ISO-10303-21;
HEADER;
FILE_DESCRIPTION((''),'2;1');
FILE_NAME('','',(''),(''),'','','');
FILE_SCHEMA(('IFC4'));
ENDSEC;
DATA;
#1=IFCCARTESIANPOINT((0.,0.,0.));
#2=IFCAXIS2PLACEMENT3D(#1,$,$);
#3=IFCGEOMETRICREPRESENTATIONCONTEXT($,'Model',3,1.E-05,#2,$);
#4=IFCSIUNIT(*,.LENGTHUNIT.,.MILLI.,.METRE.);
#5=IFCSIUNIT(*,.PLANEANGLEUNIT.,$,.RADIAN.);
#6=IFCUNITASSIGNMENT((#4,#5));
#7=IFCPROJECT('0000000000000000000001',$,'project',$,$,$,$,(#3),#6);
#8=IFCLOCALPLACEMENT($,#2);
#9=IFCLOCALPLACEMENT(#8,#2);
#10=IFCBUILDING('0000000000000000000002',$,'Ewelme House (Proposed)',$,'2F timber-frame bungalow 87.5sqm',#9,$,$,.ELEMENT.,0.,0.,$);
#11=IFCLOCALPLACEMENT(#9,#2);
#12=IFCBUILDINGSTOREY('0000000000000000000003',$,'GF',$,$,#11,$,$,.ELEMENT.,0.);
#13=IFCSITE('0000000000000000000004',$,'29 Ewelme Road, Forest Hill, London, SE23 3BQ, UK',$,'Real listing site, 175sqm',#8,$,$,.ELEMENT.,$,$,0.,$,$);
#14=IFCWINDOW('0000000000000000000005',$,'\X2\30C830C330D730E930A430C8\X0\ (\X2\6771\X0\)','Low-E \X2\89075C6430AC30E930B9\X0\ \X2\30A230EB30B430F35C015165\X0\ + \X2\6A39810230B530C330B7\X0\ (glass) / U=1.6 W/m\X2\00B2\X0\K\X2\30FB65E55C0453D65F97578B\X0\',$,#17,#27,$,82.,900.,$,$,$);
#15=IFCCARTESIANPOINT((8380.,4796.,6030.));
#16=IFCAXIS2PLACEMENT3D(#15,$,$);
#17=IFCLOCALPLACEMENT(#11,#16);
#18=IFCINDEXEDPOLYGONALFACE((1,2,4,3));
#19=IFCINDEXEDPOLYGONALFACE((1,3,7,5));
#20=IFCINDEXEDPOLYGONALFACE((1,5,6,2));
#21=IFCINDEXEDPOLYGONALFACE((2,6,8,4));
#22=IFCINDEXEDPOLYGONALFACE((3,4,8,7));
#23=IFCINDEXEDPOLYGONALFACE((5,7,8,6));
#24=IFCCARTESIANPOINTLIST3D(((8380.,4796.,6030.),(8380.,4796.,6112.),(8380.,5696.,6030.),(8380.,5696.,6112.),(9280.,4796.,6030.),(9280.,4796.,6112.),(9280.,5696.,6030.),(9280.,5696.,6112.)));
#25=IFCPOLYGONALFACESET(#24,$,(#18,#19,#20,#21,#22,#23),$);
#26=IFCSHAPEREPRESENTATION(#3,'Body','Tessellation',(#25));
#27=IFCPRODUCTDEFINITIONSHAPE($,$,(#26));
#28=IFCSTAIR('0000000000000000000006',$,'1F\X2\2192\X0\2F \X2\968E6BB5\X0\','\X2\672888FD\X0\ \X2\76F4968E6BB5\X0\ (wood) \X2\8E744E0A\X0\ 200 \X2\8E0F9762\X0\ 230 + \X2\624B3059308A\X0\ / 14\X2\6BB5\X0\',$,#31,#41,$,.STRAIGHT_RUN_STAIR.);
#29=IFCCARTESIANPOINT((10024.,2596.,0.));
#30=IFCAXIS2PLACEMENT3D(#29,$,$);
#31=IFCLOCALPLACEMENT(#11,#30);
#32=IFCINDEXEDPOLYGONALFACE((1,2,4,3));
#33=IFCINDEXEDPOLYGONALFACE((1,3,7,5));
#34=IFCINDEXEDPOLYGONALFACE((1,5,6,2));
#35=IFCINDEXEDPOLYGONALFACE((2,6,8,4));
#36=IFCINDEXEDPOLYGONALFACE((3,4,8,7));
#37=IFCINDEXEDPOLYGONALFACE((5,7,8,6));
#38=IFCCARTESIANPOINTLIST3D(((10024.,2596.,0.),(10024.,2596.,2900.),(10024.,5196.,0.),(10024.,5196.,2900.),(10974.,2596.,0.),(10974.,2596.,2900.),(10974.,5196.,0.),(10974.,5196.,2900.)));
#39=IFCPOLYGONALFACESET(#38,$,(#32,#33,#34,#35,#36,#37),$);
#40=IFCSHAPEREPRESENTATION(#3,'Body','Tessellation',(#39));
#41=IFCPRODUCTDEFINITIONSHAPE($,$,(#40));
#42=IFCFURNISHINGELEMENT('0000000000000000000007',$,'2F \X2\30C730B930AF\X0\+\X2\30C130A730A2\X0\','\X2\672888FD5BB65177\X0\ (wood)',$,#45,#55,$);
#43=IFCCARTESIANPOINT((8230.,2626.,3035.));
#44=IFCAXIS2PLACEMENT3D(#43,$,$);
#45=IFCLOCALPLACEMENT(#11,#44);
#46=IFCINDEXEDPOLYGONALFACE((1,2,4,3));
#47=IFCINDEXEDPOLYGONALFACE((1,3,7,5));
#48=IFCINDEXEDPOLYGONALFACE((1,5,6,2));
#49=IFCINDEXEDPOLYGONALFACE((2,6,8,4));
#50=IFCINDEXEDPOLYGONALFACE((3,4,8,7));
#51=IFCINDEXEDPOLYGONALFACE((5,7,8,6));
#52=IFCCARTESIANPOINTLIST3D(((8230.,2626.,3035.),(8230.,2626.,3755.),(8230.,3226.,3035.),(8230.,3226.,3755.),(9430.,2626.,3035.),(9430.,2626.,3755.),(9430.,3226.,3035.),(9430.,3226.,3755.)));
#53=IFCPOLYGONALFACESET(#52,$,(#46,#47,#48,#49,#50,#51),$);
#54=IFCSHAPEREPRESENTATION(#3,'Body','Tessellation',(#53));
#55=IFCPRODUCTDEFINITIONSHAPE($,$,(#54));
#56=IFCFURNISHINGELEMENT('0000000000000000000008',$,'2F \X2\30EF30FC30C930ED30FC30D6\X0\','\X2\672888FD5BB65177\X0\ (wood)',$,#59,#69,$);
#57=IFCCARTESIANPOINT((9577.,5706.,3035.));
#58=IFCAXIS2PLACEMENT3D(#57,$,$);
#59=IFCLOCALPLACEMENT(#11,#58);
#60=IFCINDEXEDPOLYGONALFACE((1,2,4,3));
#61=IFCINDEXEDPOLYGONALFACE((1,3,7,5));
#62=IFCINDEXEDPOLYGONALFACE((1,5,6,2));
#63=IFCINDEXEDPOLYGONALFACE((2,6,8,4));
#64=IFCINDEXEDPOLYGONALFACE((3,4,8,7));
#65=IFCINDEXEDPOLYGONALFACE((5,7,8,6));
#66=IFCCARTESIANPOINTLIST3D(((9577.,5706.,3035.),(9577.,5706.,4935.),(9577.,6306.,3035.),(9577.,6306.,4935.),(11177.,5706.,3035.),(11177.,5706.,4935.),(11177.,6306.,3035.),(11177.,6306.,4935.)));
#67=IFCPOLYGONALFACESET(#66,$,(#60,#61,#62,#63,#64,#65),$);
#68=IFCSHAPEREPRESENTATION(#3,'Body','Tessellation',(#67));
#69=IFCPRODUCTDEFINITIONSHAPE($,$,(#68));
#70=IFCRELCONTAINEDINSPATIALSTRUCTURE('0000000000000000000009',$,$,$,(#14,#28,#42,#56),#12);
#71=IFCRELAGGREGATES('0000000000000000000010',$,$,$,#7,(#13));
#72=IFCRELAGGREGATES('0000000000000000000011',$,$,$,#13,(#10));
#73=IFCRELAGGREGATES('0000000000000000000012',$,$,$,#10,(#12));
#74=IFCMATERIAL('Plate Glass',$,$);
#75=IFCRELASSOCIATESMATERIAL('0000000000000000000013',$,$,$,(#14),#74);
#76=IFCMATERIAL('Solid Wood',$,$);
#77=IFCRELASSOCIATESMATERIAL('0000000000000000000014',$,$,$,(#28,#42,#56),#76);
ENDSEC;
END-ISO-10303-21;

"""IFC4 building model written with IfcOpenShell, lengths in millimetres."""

from ifc_helpers import new_model, si_unit, frame, frame_2d, origin, place, context, project, spatial, rectangle, extrude, material, element, save


model = new_model("IFC4")

# Units and contexts
model_context = context("Model", 3, precision=1e-05, world=origin())
ifc_project = project(units=[si_unit("LENGTHUNIT", "METRE", prefix="MILLI"), si_unit("PLANEANGLEUNIT", "RADIAN")], contexts=[model_context])

# Site, building, storey
site_placement = place(None, origin())
site = spatial("IfcSite", under=ifc_project, at=site_placement, Name="29 Ewelme Road, Forest Hill, London, SE23 3BQ, UK", ObjectType="Real listing site, 175sqm", CompositionType="ELEMENT", RefElevation=0.0)
building_placement = place(site_placement, origin())
building = spatial("IfcBuilding", under=site, at=building_placement, Name="Ewelme House (Proposed)", ObjectType="2F timber-frame bungalow 87.5sqm", CompositionType="ELEMENT", ElevationOfRefHeight=0.0, ElevationOfTerrain=0.0)
storey_placement = place(building_placement, origin())
storey = spatial("IfcBuildingStorey", under=building, at=storey_placement, Name="GF", CompositionType="ELEMENT", Elevation=0.0)

# Shared definitions
ifc_material_1 = material(Name="Solid Wood")

# Shared definitions
ifc_material_2 = material(Name="Plate Glass")

# Window
window_1_placement = place(storey_placement, frame((8380.0, 4796.0, 6030.0)))
element("IfcWindow", 1, at=window_1_placement, inside=storey, material=ifc_material_2, Name="トップライト (東)", Description="Low-E 複層ガラス アルゴン封入 + 樹脂サッシ (glass) / U=1.6 W/m²K・日射取得型", OverallHeight=82.0, OverallWidth=900.0, context=model_context, shape_type="SweptSolid", body=[
    extrude(rectangle(XDim=900.0, YDim=900.0, at=frame_2d((450.0, 450.0))), frame((8380.0, 4796.0, 6030.0)), (0.0, 0.0, 1.0), 82.0),
])

# Stair
stair_placement = place(storey_placement, frame((10024.0, 2596.0, 0.0)))
element("IfcStair", 2, at=stair_placement, inside=storey, material=ifc_material_1, Name="1F→2F 階段", Description="木製 直階段 (wood) 蹴上 200 踏面 230 + 手すり / 14段", PredefinedType="STRAIGHT_RUN_STAIR", context=model_context, shape_type="SweptSolid", body=[
    extrude(rectangle(XDim=950.0, YDim=2600.0, at=frame_2d((475.0, 1300.0))), frame((10024.0, 2596.0, 0.0)), (0.0, 0.0, 1.0), 2900.0),
])

# Furnishing elements
furnishing_1_placement = place(storey_placement, frame((8230.0, 2626.0, 3035.0)))
element("IfcFurnishingElement", 3, at=furnishing_1_placement, inside=storey, material=ifc_material_1, Name="2F デスク+チェア", Description="木製家具 (wood)", context=model_context, shape_type="SweptSolid", body=[
    extrude(rectangle(XDim=1200.0, YDim=600.0, at=frame_2d((600.0, 300.0))), frame((8230.0, 2626.0, 3035.0)), (0.0, 0.0, 1.0), 720.0),
])
furnishing_2_placement = place(storey_placement, frame((9577.0, 5706.0, 3035.0)))
element("IfcFurnishingElement", 4, at=furnishing_2_placement, inside=storey, material=ifc_material_1, Name="2F ワードローブ", Description="木製家具 (wood)", context=model_context, shape_type="SweptSolid", body=[
    extrude(rectangle(XDim=1600.0, YDim=600.0, at=frame_2d((800.0, 300.0))), frame((9577.0, 5706.0, 3035.0)), (0.0, 0.0, 1.0), 1900.0),
])

save(model, "model.ifc")
